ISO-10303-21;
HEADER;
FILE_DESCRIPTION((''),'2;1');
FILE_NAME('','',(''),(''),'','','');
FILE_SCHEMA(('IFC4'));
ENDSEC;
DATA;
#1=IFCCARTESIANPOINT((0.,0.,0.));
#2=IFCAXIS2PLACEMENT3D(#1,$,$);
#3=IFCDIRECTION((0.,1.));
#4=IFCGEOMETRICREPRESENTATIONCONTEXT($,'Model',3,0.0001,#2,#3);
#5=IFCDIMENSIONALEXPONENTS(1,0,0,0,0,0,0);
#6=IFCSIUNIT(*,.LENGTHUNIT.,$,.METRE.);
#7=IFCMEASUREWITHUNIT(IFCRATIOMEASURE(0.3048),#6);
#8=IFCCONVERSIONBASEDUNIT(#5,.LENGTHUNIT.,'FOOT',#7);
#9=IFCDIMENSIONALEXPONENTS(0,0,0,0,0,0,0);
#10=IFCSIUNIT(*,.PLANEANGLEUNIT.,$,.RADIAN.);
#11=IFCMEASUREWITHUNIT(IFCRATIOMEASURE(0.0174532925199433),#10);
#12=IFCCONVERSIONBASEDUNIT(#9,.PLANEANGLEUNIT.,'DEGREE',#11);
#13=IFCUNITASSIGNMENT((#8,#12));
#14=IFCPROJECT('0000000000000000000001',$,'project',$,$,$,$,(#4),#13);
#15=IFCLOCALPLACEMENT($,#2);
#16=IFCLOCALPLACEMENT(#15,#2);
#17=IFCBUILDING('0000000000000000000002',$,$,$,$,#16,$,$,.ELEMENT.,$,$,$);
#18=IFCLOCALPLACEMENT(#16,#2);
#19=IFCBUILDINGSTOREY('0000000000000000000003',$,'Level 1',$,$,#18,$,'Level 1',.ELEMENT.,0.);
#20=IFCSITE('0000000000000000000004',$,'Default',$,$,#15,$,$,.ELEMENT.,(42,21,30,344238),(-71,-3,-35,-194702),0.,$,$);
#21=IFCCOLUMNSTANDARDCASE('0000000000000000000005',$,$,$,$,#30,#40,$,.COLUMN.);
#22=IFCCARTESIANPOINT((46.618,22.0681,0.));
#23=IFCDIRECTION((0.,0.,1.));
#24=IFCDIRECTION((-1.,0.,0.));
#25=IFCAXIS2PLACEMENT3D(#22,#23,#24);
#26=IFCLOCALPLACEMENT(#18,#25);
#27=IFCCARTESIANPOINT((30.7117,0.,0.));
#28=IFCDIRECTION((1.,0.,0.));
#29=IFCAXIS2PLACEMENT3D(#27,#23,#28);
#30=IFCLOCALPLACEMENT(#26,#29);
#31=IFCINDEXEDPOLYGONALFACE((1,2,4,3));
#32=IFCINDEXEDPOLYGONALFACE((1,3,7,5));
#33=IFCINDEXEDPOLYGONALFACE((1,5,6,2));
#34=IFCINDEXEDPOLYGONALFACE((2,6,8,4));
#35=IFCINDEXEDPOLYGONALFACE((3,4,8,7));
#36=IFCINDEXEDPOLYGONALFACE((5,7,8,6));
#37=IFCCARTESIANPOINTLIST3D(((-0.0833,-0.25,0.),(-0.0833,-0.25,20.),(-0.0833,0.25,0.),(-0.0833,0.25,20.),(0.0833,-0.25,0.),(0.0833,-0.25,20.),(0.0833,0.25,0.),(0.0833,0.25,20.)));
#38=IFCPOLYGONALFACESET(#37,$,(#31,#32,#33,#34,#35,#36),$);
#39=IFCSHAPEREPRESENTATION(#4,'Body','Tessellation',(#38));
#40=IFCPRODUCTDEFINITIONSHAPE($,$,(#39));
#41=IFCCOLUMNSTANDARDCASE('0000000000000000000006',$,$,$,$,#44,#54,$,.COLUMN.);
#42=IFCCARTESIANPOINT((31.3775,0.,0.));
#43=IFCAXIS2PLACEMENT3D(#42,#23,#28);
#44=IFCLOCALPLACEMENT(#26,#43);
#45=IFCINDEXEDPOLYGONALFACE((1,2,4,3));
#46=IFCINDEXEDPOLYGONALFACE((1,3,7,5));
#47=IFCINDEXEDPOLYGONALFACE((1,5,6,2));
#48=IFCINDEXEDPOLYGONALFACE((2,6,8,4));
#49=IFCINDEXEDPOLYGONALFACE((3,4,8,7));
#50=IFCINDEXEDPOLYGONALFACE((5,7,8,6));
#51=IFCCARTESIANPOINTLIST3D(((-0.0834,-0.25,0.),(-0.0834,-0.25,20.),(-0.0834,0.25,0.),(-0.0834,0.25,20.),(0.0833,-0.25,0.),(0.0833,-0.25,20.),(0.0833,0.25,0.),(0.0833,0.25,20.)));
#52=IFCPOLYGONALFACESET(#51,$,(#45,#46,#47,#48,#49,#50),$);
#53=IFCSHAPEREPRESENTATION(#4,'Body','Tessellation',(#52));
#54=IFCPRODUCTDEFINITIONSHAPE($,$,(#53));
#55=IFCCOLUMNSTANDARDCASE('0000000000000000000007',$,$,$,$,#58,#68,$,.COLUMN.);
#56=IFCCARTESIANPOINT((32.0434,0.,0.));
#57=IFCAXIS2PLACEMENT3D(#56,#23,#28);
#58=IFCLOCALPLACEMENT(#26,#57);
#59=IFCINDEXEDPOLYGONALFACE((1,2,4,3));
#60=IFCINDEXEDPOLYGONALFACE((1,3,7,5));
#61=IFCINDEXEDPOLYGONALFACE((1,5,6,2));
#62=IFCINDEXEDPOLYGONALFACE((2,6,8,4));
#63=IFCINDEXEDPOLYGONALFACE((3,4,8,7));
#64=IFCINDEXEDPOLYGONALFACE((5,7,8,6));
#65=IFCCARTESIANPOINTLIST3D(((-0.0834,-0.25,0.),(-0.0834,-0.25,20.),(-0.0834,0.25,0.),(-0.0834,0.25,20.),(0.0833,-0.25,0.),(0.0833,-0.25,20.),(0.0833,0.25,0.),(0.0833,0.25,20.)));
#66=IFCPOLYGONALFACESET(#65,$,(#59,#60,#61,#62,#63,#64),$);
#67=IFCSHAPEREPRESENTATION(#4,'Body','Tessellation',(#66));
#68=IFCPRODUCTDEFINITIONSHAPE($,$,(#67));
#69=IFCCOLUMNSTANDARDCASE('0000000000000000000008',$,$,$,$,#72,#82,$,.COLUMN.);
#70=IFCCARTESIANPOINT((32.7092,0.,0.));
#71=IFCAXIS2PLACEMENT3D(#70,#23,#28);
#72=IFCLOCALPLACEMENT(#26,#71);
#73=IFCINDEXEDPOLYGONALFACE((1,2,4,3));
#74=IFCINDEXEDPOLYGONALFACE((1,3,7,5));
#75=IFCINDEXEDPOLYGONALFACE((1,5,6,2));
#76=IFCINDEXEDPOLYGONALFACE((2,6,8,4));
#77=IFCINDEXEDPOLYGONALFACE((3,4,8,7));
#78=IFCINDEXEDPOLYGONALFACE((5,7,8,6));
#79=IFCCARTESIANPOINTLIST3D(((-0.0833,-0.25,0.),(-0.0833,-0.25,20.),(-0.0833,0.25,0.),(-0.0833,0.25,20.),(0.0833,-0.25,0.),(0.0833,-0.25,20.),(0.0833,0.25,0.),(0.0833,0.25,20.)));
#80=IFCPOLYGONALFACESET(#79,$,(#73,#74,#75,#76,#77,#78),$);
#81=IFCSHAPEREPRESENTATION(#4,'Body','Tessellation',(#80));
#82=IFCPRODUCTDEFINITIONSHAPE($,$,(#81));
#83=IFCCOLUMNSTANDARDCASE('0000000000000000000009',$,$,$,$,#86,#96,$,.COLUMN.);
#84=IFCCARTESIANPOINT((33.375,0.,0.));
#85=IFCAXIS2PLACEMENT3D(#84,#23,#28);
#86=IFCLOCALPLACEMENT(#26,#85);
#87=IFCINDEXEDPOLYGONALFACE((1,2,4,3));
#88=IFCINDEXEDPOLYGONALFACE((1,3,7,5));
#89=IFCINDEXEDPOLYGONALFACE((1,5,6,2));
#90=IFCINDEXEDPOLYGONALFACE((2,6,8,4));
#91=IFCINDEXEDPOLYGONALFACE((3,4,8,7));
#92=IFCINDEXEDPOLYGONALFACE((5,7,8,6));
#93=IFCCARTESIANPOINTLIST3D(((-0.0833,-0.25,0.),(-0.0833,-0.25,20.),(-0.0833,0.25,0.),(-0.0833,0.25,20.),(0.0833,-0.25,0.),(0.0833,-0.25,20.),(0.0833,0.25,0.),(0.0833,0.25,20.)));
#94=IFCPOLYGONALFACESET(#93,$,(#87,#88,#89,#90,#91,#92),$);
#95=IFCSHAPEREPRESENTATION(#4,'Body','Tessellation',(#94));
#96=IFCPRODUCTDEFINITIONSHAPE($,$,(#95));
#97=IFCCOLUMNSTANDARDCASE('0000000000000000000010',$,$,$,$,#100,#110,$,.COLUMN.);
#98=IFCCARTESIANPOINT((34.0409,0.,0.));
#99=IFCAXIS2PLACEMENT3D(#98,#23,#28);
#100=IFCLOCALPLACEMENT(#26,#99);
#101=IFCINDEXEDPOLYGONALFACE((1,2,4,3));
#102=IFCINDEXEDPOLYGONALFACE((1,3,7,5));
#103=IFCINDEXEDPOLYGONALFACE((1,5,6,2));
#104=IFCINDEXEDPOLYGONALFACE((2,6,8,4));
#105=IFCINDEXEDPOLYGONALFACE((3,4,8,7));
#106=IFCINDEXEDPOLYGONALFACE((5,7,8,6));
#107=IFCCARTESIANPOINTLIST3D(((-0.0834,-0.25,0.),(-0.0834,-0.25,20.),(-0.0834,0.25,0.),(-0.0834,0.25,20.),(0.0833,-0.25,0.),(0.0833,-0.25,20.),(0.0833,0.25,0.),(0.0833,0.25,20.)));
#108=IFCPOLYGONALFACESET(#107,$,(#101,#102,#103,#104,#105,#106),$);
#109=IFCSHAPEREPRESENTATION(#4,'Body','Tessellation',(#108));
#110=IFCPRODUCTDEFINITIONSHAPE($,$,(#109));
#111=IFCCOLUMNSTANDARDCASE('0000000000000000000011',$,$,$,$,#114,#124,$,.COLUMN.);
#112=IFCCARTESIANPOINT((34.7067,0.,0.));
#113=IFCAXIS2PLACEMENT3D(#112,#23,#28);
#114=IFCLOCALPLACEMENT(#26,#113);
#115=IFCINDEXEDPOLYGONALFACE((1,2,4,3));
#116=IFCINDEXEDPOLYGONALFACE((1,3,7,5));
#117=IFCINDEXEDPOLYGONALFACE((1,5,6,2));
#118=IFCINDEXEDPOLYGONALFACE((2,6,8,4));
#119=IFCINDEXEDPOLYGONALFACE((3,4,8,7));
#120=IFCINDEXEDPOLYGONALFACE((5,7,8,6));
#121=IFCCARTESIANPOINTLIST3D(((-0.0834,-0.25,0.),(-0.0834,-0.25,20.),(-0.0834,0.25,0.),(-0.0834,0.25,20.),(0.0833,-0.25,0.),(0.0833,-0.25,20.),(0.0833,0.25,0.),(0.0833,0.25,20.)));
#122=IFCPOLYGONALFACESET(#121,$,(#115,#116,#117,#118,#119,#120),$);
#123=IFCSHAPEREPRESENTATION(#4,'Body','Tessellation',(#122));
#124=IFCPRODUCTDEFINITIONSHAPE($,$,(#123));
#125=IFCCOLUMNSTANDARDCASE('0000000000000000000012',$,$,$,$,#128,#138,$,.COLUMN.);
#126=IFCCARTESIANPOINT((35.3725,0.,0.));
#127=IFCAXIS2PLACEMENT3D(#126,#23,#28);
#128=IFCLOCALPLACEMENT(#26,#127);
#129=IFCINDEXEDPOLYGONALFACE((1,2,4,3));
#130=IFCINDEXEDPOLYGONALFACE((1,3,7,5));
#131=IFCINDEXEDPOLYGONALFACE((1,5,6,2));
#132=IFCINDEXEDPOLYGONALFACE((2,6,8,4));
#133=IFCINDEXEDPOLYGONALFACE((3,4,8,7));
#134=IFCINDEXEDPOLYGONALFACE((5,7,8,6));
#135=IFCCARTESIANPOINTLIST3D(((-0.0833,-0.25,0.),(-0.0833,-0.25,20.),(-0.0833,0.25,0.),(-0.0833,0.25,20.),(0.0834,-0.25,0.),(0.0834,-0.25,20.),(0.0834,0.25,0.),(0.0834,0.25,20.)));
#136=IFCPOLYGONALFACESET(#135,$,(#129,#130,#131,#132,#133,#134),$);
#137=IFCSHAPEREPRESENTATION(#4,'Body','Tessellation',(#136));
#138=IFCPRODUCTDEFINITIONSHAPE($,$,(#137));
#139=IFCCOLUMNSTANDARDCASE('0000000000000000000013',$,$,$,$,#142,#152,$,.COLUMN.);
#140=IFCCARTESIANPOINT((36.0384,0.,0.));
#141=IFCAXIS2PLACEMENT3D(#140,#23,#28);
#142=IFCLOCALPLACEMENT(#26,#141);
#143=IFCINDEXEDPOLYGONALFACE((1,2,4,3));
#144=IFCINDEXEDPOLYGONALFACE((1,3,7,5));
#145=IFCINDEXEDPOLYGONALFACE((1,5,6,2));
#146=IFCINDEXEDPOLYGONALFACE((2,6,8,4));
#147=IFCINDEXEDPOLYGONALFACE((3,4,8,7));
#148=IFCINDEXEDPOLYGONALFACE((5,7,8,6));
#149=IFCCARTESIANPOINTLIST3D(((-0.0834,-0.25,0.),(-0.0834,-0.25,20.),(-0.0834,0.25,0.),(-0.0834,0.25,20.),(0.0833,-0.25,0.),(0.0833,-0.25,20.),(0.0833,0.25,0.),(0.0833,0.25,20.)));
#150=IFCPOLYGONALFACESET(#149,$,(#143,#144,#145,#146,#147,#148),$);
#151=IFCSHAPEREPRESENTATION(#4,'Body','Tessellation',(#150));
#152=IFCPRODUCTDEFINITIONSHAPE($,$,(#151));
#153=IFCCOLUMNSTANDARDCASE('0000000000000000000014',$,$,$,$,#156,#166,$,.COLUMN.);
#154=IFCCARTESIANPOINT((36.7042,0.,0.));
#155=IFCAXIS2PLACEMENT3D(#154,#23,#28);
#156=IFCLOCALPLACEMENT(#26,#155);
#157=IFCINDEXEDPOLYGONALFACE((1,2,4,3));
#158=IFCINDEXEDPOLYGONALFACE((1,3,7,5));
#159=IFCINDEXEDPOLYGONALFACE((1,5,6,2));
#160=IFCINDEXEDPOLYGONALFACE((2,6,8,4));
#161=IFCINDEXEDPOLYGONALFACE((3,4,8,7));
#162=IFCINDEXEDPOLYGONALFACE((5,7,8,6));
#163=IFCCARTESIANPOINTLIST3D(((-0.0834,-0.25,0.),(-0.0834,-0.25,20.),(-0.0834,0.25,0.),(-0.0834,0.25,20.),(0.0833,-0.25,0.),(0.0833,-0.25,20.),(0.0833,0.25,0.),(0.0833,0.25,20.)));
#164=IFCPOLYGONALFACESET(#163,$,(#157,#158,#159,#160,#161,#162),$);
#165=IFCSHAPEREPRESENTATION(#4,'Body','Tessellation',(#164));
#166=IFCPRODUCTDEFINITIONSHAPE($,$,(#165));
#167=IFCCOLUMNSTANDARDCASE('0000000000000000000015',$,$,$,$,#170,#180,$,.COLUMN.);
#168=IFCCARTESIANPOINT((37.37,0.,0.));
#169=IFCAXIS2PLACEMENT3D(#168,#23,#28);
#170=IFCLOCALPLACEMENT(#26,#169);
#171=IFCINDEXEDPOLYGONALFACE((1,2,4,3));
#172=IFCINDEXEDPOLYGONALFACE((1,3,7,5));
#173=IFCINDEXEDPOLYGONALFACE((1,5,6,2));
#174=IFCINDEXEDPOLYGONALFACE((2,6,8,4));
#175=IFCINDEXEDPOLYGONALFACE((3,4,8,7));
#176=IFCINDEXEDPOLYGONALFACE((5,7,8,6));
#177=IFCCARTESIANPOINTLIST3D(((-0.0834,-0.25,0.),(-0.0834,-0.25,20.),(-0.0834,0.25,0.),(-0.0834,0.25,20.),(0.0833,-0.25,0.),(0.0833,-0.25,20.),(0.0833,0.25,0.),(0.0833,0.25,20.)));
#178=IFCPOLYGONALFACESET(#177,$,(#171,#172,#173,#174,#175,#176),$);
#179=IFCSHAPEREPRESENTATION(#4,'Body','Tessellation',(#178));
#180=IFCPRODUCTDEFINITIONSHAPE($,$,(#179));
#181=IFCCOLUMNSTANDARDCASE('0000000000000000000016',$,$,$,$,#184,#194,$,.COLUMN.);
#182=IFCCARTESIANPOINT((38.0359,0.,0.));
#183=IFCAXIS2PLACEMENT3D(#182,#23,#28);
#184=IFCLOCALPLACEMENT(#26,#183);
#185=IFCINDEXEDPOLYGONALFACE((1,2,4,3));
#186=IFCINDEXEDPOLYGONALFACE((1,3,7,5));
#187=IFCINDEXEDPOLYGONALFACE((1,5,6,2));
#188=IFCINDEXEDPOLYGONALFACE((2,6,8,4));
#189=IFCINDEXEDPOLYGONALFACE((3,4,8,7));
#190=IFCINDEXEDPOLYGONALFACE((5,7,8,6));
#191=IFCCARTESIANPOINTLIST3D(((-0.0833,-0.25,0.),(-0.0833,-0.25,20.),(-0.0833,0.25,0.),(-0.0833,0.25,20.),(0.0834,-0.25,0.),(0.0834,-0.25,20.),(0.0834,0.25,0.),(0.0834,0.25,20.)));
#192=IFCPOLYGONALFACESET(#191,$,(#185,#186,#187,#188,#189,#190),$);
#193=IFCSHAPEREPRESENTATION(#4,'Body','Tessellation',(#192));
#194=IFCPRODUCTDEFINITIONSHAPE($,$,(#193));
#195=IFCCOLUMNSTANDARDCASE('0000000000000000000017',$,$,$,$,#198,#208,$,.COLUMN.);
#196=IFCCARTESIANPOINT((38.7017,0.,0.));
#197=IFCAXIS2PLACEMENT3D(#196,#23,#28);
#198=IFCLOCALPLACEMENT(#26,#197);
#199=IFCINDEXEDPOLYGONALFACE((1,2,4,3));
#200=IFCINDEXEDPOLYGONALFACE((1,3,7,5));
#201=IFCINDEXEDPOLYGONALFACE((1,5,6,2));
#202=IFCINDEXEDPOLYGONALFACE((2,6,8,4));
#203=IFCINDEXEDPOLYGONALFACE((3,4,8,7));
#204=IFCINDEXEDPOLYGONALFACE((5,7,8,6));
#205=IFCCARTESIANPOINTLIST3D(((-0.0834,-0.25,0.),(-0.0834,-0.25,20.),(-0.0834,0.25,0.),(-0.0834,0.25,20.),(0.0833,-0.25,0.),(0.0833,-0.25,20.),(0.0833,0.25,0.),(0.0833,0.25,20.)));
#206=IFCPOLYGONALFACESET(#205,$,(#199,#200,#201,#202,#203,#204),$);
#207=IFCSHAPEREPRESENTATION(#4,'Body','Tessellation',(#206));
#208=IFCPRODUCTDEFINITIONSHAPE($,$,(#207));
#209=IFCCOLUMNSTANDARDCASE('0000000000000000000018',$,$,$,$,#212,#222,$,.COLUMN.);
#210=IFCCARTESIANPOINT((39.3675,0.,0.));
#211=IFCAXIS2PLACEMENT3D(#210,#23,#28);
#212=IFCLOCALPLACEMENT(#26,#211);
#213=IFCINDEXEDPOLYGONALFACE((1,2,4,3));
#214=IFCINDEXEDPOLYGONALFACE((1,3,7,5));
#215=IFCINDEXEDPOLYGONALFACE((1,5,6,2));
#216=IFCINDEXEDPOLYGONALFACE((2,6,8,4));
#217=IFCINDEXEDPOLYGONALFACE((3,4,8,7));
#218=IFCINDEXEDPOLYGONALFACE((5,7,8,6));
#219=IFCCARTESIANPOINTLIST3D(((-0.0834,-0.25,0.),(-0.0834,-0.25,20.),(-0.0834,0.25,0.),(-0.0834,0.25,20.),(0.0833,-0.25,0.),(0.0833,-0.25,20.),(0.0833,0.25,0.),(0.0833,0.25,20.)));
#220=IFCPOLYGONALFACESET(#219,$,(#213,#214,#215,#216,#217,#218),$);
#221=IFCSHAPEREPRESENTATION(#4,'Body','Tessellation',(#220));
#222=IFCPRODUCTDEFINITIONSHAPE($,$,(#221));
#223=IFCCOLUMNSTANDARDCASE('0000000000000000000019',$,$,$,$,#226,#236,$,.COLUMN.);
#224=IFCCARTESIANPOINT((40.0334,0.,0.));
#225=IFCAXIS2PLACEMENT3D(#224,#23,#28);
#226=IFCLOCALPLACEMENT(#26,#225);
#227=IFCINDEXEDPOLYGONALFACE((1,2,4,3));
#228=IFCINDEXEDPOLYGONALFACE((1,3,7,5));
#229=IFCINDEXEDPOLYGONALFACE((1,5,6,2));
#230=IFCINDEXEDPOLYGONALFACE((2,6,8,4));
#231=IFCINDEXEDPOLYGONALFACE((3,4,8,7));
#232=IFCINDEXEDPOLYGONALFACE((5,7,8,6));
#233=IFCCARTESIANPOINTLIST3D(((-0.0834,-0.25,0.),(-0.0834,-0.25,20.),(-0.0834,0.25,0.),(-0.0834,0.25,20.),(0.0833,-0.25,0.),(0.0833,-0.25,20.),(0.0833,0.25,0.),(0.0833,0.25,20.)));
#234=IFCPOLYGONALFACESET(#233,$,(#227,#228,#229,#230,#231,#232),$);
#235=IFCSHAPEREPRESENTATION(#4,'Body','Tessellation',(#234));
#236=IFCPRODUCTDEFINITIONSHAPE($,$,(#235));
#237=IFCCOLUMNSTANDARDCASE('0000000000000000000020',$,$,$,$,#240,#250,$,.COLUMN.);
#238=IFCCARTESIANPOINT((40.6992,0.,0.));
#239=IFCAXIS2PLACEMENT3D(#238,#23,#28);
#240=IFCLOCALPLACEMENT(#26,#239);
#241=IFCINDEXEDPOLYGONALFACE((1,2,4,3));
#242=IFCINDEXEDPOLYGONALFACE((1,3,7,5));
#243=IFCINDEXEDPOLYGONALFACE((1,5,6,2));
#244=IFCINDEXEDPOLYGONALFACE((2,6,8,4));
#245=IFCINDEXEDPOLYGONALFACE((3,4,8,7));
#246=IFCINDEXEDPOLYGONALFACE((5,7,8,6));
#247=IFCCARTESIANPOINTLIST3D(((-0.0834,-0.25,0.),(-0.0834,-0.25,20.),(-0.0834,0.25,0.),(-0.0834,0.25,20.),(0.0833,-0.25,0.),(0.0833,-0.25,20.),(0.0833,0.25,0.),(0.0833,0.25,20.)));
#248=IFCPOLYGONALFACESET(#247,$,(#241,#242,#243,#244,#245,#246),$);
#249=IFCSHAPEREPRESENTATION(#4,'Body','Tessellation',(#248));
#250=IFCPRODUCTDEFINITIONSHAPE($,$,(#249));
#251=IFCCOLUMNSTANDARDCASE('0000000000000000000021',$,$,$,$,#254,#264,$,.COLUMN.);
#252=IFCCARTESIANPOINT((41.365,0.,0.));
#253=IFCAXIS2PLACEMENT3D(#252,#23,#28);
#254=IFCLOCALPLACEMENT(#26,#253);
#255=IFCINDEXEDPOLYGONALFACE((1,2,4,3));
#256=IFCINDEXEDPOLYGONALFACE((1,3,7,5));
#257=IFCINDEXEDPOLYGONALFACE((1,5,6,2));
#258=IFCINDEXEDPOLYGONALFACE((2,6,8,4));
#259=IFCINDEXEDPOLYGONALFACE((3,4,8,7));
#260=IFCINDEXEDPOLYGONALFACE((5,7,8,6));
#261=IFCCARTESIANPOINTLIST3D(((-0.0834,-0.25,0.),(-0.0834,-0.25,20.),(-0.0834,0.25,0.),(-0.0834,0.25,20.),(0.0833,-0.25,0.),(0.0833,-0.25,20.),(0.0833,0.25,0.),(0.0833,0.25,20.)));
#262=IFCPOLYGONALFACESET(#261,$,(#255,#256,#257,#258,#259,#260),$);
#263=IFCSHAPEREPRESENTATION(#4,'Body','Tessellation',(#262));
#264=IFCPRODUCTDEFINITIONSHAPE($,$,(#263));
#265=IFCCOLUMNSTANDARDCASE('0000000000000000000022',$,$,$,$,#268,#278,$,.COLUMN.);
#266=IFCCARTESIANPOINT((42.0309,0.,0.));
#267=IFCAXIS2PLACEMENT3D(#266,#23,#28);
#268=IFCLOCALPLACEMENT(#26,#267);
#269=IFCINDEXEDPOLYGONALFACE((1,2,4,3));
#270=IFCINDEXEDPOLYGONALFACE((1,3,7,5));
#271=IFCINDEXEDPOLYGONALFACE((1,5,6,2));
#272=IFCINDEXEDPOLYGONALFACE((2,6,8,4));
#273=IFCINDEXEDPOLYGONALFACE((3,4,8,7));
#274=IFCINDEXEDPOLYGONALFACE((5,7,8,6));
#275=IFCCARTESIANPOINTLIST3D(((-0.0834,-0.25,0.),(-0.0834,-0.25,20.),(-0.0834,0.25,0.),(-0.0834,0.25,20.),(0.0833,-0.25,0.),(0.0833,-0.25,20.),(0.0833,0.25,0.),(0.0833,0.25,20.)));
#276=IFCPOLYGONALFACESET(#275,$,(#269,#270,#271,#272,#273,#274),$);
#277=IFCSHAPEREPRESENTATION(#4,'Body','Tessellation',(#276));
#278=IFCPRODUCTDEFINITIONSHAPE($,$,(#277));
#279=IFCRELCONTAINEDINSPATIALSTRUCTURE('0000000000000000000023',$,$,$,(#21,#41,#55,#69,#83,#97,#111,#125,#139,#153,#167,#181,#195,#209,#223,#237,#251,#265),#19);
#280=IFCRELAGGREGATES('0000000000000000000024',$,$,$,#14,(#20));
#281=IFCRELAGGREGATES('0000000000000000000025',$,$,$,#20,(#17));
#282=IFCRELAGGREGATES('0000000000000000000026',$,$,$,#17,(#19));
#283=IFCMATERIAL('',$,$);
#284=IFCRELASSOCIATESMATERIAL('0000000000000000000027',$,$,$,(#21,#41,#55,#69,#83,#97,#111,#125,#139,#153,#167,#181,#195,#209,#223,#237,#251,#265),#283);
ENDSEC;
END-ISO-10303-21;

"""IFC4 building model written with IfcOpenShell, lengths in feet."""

from ifc_helpers import new_model, entity, si_unit, converted_unit, direction, frame, origin, place, context, project, spatial, rectangle, extrude, material, element, save


model = new_model("IFC4")

# Units and contexts
model_context = context("Model", 3, precision=0.0001, world=origin(), true_north=direction((0.0, 1.0)))
ifc_project = project(units=[converted_unit("LENGTHUNIT", "FOOT", entity("IfcRatioMeasure", 0.3048), si_unit("LENGTHUNIT", "METRE"), dimensions=[1, 0, 0, 0, 0, 0, 0]), converted_unit("PLANEANGLEUNIT", "DEGREE", entity("IfcRatioMeasure", 0.0174532925199433), si_unit("PLANEANGLEUNIT", "RADIAN"), dimensions=[0, 0, 0, 0, 0, 0, 0])], contexts=[model_context])

# Site, building, storey
site_placement = place(None, origin())
site = spatial("IfcSite", under=ifc_project, at=site_placement, Name="Default", CompositionType="ELEMENT", RefLatitude=(42, 21, 30, 344238), RefLongitude=(-71, -3, -35, -194702), RefElevation=0.0)
building_placement = place(site_placement, origin())
building = spatial("IfcBuilding", under=site, at=building_placement, CompositionType="ELEMENT")
storey_placement = place(building_placement, origin())
storey = spatial("IfcBuildingStorey", under=building, at=storey_placement, Name="Level 1", LongName="Level 1", CompositionType="ELEMENT", Elevation=0.0)

# Columns
ifc_material = material(Name="")
placement = place(storey_placement, frame((46.618, 22.0681, 0.0), z_axis=(0.0, 0.0, 1.0), x_axis=(-1.0, 0.0, 0.0)))
for number, where, z_axis, x_axis in (
    (1, (30.7117, 0.0, 0.0), (0.0, 0.0, 1.0), (1.0, 0.0, 0.0)),
    (2, (31.3775, 0.0, 0.0), (0.0, 0.0, 1.0), (1.0, 0.0, 0.0)),
    (3, (32.0434, 0.0, 0.0), (0.0, 0.0, 1.0), (1.0, 0.0, 0.0)),
    (4, (32.7092, 0.0, 0.0), (0.0, 0.0, 1.0), (1.0, 0.0, 0.0)),
    (5, (33.375, 0.0, 0.0), (0.0, 0.0, 1.0), (1.0, 0.0, 0.0)),
    (6, (34.0409, 0.0, 0.0), (0.0, 0.0, 1.0), (1.0, 0.0, 0.0)),
    (7, (34.7067, 0.0, 0.0), (0.0, 0.0, 1.0), (1.0, 0.0, 0.0)),
    (8, (35.3725, 0.0, 0.0), (0.0, 0.0, 1.0), (1.0, 0.0, 0.0)),
    (9, (36.0384, 0.0, 0.0), (0.0, 0.0, 1.0), (1.0, 0.0, 0.0)),
    (10, (36.7042, 0.0, 0.0), (0.0, 0.0, 1.0), (1.0, 0.0, 0.0)),
    (11, (37.37, 0.0, 0.0), (0.0, 0.0, 1.0), (1.0, 0.0, 0.0)),
    (12, (38.0359, 0.0, 0.0), (0.0, 0.0, 1.0), (1.0, 0.0, 0.0)),
    (13, (38.7017, 0.0, 0.0), (0.0, 0.0, 1.0), (1.0, 0.0, 0.0)),
    (14, (39.3675, 0.0, 0.0), (0.0, 0.0, 1.0), (1.0, 0.0, 0.0)),
    (15, (40.0334, 0.0, 0.0), (0.0, 0.0, 1.0), (1.0, 0.0, 0.0)),
    (16, (40.6992, 0.0, 0.0), (0.0, 0.0, 1.0), (1.0, 0.0, 0.0)),
    (17, (41.365, 0.0, 0.0), (0.0, 0.0, 1.0), (1.0, 0.0, 0.0)),
    (18, (42.0309, 0.0, 0.0), (0.0, 0.0, 1.0), (1.0, 0.0, 0.0)),
):
    element("IfcColumnStandardCase", number, at=place(placement, frame(where, z_axis=z_axis, x_axis=x_axis)), inside=storey, material=ifc_material, PredefinedType="COLUMN", context=model_context, shape_type="SweptSolid", body=[
        extrude(rectangle(XDim=0.1667, YDim=0.5), origin(), (0.0, 0.0, 1.0), 20.0),
    ])

save(model, "model.ifc")
